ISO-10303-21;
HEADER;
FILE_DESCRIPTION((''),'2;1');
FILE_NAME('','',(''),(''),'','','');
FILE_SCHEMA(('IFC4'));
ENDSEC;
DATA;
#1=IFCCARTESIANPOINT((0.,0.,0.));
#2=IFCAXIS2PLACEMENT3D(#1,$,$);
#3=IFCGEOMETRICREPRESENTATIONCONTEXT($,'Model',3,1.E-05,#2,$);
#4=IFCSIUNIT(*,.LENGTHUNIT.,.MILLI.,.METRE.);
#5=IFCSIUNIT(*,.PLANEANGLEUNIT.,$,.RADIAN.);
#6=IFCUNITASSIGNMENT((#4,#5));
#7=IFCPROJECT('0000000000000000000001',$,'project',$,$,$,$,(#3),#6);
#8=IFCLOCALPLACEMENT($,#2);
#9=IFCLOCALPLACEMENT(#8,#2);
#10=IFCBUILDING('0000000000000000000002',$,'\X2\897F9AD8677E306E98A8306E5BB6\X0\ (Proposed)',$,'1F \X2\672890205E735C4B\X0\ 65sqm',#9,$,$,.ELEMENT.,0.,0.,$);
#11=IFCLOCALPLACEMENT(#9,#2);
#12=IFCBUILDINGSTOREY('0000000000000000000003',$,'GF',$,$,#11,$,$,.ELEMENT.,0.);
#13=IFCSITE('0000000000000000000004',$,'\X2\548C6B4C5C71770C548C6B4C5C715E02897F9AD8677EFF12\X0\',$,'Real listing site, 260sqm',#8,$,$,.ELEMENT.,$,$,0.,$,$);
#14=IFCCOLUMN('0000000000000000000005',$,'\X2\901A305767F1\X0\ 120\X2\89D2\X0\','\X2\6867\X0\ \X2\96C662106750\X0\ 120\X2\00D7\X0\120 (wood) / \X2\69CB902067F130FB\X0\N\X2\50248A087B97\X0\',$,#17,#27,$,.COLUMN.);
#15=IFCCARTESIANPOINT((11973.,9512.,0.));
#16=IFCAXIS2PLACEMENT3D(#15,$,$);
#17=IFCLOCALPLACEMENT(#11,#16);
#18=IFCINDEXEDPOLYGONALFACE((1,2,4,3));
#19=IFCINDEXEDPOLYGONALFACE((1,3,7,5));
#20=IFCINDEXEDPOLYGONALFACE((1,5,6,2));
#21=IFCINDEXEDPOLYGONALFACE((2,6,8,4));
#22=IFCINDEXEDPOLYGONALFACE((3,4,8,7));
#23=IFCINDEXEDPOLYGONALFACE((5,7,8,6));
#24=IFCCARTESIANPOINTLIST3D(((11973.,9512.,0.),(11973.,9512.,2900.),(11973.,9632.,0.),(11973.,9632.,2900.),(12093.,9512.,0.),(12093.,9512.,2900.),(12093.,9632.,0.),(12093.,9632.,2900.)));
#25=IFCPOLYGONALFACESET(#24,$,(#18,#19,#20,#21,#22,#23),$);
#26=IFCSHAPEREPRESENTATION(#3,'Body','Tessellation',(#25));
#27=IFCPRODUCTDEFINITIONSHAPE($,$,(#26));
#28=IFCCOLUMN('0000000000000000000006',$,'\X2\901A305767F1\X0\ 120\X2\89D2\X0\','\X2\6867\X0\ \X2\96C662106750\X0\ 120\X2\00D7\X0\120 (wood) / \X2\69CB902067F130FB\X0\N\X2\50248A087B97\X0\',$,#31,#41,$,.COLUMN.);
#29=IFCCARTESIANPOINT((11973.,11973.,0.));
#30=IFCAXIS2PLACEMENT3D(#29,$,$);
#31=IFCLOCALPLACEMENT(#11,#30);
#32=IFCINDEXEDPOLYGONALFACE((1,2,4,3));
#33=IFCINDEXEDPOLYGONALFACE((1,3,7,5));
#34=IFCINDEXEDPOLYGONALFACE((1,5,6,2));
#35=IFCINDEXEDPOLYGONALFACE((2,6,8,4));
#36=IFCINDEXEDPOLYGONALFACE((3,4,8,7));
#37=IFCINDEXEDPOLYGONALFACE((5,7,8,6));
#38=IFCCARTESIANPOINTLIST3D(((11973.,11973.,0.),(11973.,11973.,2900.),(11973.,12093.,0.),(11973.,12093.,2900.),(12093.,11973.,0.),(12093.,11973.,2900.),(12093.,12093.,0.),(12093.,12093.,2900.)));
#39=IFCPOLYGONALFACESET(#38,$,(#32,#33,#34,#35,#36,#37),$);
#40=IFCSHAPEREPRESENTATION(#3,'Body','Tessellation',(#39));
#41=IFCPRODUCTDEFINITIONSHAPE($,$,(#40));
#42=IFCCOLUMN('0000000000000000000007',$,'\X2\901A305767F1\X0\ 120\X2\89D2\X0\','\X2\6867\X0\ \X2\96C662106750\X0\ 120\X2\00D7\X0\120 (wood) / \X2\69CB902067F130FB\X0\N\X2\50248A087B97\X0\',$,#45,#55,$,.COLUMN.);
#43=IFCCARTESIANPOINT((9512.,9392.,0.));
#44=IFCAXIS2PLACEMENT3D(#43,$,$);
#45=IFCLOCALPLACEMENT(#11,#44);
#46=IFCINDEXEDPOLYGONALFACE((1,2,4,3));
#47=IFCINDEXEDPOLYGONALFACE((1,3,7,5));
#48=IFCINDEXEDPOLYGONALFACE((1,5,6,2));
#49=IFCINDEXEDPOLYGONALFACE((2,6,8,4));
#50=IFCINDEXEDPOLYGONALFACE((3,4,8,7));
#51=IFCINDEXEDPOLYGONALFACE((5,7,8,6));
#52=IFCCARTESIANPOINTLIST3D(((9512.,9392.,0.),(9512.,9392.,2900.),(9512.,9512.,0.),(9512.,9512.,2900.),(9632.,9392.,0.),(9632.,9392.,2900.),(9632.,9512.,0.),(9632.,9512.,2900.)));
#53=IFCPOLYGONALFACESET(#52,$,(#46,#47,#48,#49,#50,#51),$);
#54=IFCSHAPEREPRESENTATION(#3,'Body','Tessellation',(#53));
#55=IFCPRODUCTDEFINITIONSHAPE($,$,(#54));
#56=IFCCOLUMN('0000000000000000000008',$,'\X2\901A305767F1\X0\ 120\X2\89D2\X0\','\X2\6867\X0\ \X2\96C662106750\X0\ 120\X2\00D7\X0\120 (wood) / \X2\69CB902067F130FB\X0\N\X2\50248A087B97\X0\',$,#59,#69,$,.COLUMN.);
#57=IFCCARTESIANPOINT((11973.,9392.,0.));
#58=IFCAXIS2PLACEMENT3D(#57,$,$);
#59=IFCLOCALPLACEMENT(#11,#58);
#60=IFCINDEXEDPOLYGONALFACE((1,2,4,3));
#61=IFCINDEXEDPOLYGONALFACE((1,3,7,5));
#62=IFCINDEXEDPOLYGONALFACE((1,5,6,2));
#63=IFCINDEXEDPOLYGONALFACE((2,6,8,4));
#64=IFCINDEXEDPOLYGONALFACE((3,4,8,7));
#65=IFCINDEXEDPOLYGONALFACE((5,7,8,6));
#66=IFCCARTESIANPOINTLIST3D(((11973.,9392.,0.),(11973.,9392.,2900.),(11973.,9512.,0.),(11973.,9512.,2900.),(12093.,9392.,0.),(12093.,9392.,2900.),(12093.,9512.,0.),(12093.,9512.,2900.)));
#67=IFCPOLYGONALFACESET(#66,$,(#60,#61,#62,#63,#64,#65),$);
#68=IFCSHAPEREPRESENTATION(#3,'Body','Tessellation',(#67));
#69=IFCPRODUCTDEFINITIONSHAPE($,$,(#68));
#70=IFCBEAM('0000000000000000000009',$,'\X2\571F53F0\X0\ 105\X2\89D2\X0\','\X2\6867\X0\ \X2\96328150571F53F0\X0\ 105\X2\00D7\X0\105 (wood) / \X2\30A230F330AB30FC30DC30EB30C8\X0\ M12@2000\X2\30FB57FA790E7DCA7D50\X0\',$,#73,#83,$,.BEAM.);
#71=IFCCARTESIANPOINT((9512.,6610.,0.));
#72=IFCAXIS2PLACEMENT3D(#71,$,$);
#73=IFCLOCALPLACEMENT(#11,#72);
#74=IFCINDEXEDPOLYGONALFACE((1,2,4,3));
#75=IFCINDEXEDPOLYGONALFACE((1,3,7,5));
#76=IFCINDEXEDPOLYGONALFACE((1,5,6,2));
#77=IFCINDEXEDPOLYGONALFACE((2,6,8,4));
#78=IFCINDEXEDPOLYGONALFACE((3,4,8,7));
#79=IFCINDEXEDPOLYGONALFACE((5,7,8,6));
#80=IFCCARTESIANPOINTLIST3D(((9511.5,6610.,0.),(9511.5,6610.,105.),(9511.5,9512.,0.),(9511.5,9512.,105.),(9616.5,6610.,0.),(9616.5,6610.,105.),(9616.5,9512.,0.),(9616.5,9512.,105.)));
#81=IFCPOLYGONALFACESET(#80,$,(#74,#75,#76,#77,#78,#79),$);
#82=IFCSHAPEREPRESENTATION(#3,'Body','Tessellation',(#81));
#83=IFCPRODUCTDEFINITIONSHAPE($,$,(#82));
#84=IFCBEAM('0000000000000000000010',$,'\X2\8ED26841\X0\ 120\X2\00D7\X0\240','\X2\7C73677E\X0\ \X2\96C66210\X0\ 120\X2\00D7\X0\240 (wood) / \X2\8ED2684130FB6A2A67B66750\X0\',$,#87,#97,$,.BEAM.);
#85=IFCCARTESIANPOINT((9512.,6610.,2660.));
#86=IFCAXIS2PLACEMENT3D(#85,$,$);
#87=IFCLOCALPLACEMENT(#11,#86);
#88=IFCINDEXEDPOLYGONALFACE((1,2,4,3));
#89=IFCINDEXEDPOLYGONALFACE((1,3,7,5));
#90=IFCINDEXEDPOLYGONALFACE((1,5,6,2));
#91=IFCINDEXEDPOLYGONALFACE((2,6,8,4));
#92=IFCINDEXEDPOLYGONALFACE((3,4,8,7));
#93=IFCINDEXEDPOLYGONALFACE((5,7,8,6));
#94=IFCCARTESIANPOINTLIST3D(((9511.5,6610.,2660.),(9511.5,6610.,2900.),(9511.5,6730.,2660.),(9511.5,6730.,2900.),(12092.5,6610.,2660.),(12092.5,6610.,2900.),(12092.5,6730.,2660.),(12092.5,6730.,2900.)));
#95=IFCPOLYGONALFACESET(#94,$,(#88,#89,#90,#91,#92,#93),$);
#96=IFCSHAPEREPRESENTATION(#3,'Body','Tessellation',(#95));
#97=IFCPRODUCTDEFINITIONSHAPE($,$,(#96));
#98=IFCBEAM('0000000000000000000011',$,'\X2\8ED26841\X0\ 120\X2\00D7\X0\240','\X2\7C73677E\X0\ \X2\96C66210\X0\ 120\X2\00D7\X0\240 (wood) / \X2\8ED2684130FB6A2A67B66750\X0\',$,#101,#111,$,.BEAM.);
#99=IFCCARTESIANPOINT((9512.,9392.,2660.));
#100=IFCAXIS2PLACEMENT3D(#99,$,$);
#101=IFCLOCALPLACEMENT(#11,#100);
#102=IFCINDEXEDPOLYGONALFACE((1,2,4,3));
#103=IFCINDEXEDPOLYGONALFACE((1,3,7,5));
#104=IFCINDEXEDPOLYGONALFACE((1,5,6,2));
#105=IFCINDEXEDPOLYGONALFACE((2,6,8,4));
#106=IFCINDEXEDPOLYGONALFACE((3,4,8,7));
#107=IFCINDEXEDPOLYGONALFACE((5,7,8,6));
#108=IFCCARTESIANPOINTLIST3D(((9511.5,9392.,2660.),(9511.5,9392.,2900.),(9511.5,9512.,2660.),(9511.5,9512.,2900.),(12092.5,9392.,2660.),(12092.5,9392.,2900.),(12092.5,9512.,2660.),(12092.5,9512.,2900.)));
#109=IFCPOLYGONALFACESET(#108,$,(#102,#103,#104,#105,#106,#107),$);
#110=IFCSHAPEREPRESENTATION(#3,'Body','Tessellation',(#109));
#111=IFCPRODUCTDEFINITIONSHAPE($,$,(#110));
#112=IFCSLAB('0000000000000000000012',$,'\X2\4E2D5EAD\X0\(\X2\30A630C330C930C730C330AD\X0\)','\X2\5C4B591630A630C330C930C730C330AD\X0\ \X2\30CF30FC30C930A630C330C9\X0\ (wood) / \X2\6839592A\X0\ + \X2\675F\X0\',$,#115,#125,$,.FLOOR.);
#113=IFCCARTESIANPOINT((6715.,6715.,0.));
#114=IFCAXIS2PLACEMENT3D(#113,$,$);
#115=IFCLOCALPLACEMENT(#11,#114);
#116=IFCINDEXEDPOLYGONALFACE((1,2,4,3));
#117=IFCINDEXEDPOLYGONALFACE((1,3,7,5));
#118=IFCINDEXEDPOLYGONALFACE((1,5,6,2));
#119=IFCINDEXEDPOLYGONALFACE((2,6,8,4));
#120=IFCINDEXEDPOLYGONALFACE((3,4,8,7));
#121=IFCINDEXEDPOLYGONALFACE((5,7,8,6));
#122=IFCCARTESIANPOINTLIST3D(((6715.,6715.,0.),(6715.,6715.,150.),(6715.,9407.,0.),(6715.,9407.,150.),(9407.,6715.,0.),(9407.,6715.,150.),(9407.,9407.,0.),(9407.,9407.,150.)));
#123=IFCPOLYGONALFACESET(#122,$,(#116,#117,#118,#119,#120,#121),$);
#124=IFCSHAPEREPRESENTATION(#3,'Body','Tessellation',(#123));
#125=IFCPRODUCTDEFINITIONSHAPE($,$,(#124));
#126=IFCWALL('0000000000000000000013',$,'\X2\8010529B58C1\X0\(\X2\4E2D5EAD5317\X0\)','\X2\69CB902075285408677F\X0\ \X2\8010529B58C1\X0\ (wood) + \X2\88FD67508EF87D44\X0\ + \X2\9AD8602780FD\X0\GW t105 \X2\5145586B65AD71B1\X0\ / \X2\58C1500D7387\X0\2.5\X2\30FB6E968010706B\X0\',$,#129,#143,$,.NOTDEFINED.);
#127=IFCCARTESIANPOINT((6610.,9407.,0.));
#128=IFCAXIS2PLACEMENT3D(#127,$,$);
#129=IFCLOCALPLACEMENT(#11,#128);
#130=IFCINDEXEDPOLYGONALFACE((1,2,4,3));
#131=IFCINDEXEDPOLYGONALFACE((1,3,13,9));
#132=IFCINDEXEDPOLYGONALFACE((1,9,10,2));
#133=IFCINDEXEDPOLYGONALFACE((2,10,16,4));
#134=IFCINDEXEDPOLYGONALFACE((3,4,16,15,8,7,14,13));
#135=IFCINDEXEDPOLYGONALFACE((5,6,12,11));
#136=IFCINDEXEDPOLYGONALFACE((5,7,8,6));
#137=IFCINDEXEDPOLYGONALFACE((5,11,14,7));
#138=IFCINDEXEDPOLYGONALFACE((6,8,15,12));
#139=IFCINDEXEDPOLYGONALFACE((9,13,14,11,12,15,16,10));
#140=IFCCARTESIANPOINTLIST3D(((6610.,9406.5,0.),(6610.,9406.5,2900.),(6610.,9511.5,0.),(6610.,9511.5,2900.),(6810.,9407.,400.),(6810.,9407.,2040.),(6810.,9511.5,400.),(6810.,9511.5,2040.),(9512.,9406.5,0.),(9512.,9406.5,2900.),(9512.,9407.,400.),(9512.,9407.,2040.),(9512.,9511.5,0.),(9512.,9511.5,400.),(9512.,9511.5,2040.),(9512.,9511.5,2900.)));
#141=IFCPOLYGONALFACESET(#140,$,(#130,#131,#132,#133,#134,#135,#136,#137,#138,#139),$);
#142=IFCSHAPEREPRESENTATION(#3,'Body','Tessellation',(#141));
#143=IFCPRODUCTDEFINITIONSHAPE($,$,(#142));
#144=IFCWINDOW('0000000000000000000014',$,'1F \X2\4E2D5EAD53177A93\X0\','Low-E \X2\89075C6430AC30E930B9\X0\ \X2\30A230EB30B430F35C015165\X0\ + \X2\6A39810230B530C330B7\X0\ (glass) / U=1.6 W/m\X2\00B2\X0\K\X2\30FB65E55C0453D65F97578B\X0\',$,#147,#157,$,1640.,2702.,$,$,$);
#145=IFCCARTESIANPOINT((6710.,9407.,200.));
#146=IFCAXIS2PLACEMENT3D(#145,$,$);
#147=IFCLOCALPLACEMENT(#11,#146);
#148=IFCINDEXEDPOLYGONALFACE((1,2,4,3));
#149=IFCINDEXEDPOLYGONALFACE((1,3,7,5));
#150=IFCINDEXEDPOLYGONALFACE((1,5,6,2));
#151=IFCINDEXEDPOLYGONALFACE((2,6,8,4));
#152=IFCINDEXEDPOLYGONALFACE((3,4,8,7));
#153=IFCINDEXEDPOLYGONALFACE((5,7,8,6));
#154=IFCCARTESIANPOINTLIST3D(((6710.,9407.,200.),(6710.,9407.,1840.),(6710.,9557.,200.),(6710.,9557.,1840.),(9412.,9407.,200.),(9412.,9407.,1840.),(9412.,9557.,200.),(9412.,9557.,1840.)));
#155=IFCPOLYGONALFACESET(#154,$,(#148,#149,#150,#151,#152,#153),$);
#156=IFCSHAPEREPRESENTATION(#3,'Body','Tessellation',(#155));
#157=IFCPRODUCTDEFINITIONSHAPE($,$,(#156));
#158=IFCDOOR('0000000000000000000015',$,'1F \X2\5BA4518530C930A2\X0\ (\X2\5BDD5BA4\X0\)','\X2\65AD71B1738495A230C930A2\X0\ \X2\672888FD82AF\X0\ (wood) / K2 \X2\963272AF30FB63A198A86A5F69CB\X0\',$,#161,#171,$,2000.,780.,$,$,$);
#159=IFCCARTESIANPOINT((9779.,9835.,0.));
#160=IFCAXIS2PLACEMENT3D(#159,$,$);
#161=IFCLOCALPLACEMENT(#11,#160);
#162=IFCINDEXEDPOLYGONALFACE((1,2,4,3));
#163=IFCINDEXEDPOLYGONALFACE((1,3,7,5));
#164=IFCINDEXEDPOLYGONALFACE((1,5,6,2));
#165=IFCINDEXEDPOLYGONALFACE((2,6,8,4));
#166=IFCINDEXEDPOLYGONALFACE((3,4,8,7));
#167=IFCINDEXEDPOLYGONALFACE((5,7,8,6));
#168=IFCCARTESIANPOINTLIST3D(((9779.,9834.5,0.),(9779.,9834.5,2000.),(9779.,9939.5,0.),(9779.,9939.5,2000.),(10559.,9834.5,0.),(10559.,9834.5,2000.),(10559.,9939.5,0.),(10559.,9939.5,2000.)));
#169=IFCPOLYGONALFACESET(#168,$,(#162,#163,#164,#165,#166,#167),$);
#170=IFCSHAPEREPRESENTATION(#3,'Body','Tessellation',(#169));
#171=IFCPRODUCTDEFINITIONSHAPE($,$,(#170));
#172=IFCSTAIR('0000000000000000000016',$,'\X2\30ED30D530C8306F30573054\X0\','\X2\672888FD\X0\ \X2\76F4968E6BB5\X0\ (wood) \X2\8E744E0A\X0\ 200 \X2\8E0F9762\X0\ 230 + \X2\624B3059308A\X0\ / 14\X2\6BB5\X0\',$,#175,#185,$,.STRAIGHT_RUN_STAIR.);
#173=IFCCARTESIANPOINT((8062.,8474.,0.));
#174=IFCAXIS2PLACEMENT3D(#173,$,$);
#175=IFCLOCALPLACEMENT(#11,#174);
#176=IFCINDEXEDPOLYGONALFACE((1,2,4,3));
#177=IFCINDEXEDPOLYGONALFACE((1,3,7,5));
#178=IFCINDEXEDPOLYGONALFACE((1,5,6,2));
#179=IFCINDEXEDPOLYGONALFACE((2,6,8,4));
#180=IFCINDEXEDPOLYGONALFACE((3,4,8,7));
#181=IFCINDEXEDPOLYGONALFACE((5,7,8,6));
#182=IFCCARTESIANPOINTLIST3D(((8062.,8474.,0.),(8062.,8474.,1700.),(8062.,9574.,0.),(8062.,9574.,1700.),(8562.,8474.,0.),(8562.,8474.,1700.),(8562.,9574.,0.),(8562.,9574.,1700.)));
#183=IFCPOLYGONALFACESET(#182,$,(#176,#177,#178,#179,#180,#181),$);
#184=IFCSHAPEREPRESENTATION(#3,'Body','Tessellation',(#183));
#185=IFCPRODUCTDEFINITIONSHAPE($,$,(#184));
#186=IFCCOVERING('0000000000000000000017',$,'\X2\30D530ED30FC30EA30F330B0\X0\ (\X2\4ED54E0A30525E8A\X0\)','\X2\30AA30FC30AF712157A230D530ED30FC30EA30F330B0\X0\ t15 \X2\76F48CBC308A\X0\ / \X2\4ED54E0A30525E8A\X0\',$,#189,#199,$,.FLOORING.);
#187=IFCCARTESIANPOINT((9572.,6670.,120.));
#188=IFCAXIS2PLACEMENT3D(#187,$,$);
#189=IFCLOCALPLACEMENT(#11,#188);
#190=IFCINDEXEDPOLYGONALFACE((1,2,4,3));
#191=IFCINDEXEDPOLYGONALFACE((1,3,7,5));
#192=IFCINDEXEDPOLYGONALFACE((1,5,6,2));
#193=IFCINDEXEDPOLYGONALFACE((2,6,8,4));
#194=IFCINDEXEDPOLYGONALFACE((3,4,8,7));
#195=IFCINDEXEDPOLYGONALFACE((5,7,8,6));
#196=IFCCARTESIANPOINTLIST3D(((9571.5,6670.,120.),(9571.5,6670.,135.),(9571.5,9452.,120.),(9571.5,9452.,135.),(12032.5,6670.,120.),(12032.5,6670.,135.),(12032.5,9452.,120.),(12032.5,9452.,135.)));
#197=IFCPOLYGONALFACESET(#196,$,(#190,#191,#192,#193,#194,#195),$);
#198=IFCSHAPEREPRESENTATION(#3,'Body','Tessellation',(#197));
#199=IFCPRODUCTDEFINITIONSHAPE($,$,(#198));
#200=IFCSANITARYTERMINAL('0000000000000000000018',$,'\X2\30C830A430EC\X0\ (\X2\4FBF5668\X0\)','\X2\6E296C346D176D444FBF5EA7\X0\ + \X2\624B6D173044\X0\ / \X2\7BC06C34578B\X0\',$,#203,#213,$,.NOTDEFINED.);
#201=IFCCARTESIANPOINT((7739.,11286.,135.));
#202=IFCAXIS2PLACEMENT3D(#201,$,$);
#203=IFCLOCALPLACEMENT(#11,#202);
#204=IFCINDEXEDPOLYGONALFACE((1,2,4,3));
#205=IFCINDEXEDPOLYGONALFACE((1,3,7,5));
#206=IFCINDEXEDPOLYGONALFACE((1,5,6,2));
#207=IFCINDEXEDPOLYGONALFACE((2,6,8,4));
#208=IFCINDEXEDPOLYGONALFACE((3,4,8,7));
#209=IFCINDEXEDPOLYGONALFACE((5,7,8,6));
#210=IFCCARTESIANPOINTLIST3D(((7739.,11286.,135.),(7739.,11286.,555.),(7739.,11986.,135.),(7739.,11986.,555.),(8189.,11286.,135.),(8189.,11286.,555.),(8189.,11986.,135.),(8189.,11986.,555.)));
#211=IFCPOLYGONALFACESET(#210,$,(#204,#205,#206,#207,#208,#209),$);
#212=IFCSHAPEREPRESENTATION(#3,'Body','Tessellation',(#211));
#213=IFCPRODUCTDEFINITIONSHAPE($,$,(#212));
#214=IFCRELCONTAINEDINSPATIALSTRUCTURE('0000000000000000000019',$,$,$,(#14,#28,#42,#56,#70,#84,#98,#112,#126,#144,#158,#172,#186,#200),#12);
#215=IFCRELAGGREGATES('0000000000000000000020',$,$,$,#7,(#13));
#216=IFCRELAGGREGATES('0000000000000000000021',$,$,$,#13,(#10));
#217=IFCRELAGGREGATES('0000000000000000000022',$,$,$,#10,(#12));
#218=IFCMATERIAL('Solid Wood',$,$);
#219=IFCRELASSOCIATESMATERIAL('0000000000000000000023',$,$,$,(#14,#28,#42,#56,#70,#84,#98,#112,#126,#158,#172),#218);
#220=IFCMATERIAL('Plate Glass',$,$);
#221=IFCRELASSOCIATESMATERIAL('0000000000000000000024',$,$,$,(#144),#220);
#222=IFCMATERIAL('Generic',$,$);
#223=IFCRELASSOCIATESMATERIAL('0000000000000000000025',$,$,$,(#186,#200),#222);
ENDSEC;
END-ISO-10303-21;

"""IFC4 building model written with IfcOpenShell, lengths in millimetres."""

from ifc_helpers import new_model, si_unit, frame, frame_2d, origin, place, context, project, spatial, rectangle, extrude, material, element, fill, save


model = new_model("IFC4")

# Units and contexts
model_context = context("Model", 3, precision=1e-05, world=origin())
ifc_project = project(units=[si_unit("LENGTHUNIT", "METRE", prefix="MILLI"), si_unit("PLANEANGLEUNIT", "RADIAN")], contexts=[model_context])

# Site, building, storey
site_placement = place(None, origin())
site = spatial("IfcSite", under=ifc_project, at=site_placement, Name="和歌山県和歌山市西高松２", ObjectType="Real listing site, 260sqm", CompositionType="ELEMENT", RefElevation=0.0)
building_placement = place(site_placement, origin())
building = spatial("IfcBuilding", under=site, at=building_placement, Name="西高松の風の家 (Proposed)", ObjectType="1F 木造平屋 65sqm", CompositionType="ELEMENT", ElevationOfRefHeight=0.0, ElevationOfTerrain=0.0)
storey_placement = place(building_placement, origin())
storey = spatial("IfcBuildingStorey", under=building, at=storey_placement, Name="GF", CompositionType="ELEMENT", Elevation=0.0)

# Columns
ifc_material_1 = material(Name="Solid Wood")
column_1_placement = place(storey_placement, frame((11973.0, 9512.0, 0.0)))
element("IfcColumn", 1, at=column_1_placement, inside=storey, material=ifc_material_1, Name="通し柱 120角", Description="桧 集成材 120×120 (wood) / 構造柱・N値計算", PredefinedType="COLUMN", context=model_context, shape_type="SweptSolid", body=[
    extrude(rectangle(XDim=120.0, YDim=120.0, at=frame_2d((60.0, 60.0))), frame((11973.0, 9512.0, 0.0)), (0.0, 0.0, 1.0), 2900.0),
])
column_2_placement = place(storey_placement, frame((11973.0, 11973.0, 0.0)))
element("IfcColumn", 2, at=column_2_placement, inside=storey, material=ifc_material_1, Name="通し柱 120角", Description="桧 集成材 120×120 (wood) / 構造柱・N値計算", PredefinedType="COLUMN", context=model_context, shape_type="SweptSolid", body=[
    extrude(rectangle(XDim=120.0, YDim=120.0, at=frame_2d((60.0, 60.0))), frame((11973.0, 11973.0, 0.0)), (0.0, 0.0, 1.0), 2900.0),
])
column_3_placement = place(storey_placement, frame((9512.0, 9392.0, 0.0)))
element("IfcColumn", 3, at=column_3_placement, inside=storey, material=ifc_material_1, Name="通し柱 120角", Description="桧 集成材 120×120 (wood) / 構造柱・N値計算", PredefinedType="COLUMN", context=model_context, shape_type="SweptSolid", body=[
    extrude(rectangle(XDim=120.0, YDim=120.0, at=frame_2d((60.0, 60.0))), frame((9512.0, 9392.0, 0.0)), (0.0, 0.0, 1.0), 2900.0),
])
column_4_placement = place(storey_placement, frame((11973.0, 9392.0, 0.0)))
element("IfcColumn", 4, at=column_4_placement, inside=storey, material=ifc_material_1, Name="通し柱 120角", Description="桧 集成材 120×120 (wood) / 構造柱・N値計算", PredefinedType="COLUMN", context=model_context, shape_type="SweptSolid", body=[
    extrude(rectangle(XDim=120.0, YDim=120.0, at=frame_2d((60.0, 60.0))), frame((11973.0, 9392.0, 0.0)), (0.0, 0.0, 1.0), 2900.0),
])

# Beams
beam_1_placement = place(storey_placement, frame((9512.0, 6610.0, 0.0)))
element("IfcBeam", 5, at=beam_1_placement, inside=storey, material=ifc_material_1, Name="土台 105角", Description="桧 防腐土台 105×105 (wood) / アンカーボルト M12@2000・基礎緊結", PredefinedType="BEAM", context=model_context, shape_type="SweptSolid", body=[
    extrude(rectangle(XDim=105.0, YDim=2902.0, at=frame_2d((52.0, 1451.0))), frame((9512.0, 6610.0, 0.0)), (0.0, 0.0, 1.0), 105.0),
])
beam_2_placement = place(storey_placement, frame((9512.0, 6610.0, 2660.0)))
element("IfcBeam", 6, at=beam_2_placement, inside=storey, material=ifc_material_1, Name="軒桁 120×240", Description="米松 集成 120×240 (wood) / 軒桁・横架材", PredefinedType="BEAM", context=model_context, shape_type="SweptSolid", body=[
    extrude(rectangle(XDim=2581.0, YDim=120.0, at=frame_2d((1290.0, 60.0))), frame((9512.0, 6610.0, 2660.0)), (0.0, 0.0, 1.0), 240.0),
])
beam_3_placement = place(storey_placement, frame((9512.0, 9392.0, 2660.0)))
element("IfcBeam", 7, at=beam_3_placement, inside=storey, material=ifc_material_1, Name="軒桁 120×240", Description="米松 集成 120×240 (wood) / 軒桁・横架材", PredefinedType="BEAM", context=model_context, shape_type="SweptSolid", body=[
    extrude(rectangle(XDim=2581.0, YDim=120.0, at=frame_2d((1290.0, 60.0))), frame((9512.0, 9392.0, 2660.0)), (0.0, 0.0, 1.0), 240.0),
])

# Slab
slab_placement = place(storey_placement, frame((6715.0, 6715.0, 0.0)))
element("IfcSlab", 8, at=slab_placement, inside=storey, material=ifc_material_1, Name="中庭(ウッドデッキ)", Description="屋外ウッドデッキ ハードウッド (wood) / 根太 + 束", PredefinedType="FLOOR", context=model_context, shape_type="SweptSolid", body=[
    extrude(rectangle(XDim=2692.0, YDim=2692.0, at=frame_2d((1346.0, 1346.0))), frame((6715.0, 6715.0, 0.0)), (0.0, 0.0, 1.0), 150.0),
])

# Wall, opening, window
wall_1_placement = place(storey_placement, frame((6610.0, 9407.0, 0.0)))
wall_1 = element("IfcWall", 9, at=wall_1_placement, inside=storey, material=ifc_material_1, Name="耐力壁(中庭北)", Description="構造用合板 耐力壁 (wood) + 製材軸組 + 高性能GW t105 充填断熱 / 壁倍率2.5・準耐火", PredefinedType="NOTDEFINED", context=model_context, shape_type="SweptSolid", body=[
    extrude(rectangle(XDim=2902.0, YDim=105.0, at=frame_2d((1451.0, 52.0))), frame((6610.0, 9407.0, 0.0)), (0.0, 0.0, 1.0), 2900.0),
])
opening_placement = place(storey_placement, frame((6710.0, 9407.0, 200.0)))
opening = element("IfcOpeningElement", 10, at=opening_placement, cuts=wall_1, PredefinedType="NOTDEFINED", context=model_context, shape_type="SweptSolid", body=[
    extrude(rectangle(XDim=2702.0, YDim=150.0, at=frame_2d((1351.0, 75.0))), frame((6710.0, 9407.0, 200.0)), (0.0, 0.0, 1.0), 1640.0),
])
ifc_material_2 = material(Name="Plate Glass")
window_placement = place(storey_placement, frame((6710.0, 9407.0, 200.0)))
window = element("IfcWindow", 11, at=window_placement, inside=storey, material=ifc_material_2, Name="1F 中庭北窓", Description="Low-E 複層ガラス アルゴン封入 + 樹脂サッシ (glass) / U=1.6 W/m²K・日射取得型", OverallHeight=1640.0, OverallWidth=2702.0, context=model_context, shape_type="SweptSolid", body=[
    extrude(rectangle(XDim=2702.0, YDim=150.0, at=frame_2d((1351.0, 75.0))), frame((6710.0, 9407.0, 200.0)), (0.0, 0.0, 1.0), 1640.0),
])
fill(opening, window)

# Door
door_placement = place(storey_placement, frame((9779.0, 9835.0, 0.0)))
element("IfcDoor", 12, at=door_placement, inside=storey, material=ifc_material_1, Name="1F 室内ドア (寝室)", Description="断熱玄関ドア 木製芯 (wood) / K2 防犯・採風機構", OverallHeight=2000.0, OverallWidth=780.0, context=model_context, shape_type="SweptSolid", body=[
    extrude(rectangle(XDim=780.0, YDim=105.0, at=frame_2d((390.0, 52.0))), frame((9779.0, 9835.0, 0.0)), (0.0, 0.0, 1.0), 2000.0),
])

# Stair
stair_placement = place(storey_placement, frame((8062.0, 8474.0, 0.0)))
element("IfcStair", 13, at=stair_placement, inside=storey, material=ifc_material_1, Name="ロフトはしご", Description="木製 直階段 (wood) 蹴上 200 踏面 230 + 手すり / 14段", PredefinedType="STRAIGHT_RUN_STAIR", context=model_context, shape_type="SweptSolid", body=[
    extrude(rectangle(XDim=500.0, YDim=1100.0, at=frame_2d((250.0, 550.0))), frame((8062.0, 8474.0, 0.0)), (0.0, 0.0, 1.0), 1700.0),
])

# Covering
ifc_material_3 = material(Name="Generic")
covering_placement = place(storey_placement, frame((9572.0, 6670.0, 120.0)))
element("IfcCovering", 14, at=covering_placement, inside=storey, material=ifc_material_3, Name="フローリング (仕上げ床)", Description="オーク無垢フローリング t15 直貼り / 仕上げ床", PredefinedType="FLOORING", context=model_context, shape_type="SweptSolid", body=[
    extrude(rectangle(XDim=2461.0, YDim=2782.0, at=frame_2d((1230.0, 1391.0))), frame((9572.0, 6670.0, 120.0)), (0.0, 0.0, 1.0), 15.0),
])

# Sanitary terminal
sanitary_terminal_placement = place(storey_placement, frame((7739.0, 11286.0, 135.0)))
element("IfcSanitaryTerminal", 15, at=sanitary_terminal_placement, inside=storey, material=ifc_material_3, Name="トイレ (便器)", Description="温水洗浄便座 + 手洗い / 節水型", PredefinedType="NOTDEFINED", context=model_context, shape_type="SweptSolid", body=[
    extrude(rectangle(XDim=450.0, YDim=700.0, at=frame_2d((225.0, 350.0))), frame((7739.0, 11286.0, 135.0)), (0.0, 0.0, 1.0), 420.0),
])

save(model, "model.ifc")
